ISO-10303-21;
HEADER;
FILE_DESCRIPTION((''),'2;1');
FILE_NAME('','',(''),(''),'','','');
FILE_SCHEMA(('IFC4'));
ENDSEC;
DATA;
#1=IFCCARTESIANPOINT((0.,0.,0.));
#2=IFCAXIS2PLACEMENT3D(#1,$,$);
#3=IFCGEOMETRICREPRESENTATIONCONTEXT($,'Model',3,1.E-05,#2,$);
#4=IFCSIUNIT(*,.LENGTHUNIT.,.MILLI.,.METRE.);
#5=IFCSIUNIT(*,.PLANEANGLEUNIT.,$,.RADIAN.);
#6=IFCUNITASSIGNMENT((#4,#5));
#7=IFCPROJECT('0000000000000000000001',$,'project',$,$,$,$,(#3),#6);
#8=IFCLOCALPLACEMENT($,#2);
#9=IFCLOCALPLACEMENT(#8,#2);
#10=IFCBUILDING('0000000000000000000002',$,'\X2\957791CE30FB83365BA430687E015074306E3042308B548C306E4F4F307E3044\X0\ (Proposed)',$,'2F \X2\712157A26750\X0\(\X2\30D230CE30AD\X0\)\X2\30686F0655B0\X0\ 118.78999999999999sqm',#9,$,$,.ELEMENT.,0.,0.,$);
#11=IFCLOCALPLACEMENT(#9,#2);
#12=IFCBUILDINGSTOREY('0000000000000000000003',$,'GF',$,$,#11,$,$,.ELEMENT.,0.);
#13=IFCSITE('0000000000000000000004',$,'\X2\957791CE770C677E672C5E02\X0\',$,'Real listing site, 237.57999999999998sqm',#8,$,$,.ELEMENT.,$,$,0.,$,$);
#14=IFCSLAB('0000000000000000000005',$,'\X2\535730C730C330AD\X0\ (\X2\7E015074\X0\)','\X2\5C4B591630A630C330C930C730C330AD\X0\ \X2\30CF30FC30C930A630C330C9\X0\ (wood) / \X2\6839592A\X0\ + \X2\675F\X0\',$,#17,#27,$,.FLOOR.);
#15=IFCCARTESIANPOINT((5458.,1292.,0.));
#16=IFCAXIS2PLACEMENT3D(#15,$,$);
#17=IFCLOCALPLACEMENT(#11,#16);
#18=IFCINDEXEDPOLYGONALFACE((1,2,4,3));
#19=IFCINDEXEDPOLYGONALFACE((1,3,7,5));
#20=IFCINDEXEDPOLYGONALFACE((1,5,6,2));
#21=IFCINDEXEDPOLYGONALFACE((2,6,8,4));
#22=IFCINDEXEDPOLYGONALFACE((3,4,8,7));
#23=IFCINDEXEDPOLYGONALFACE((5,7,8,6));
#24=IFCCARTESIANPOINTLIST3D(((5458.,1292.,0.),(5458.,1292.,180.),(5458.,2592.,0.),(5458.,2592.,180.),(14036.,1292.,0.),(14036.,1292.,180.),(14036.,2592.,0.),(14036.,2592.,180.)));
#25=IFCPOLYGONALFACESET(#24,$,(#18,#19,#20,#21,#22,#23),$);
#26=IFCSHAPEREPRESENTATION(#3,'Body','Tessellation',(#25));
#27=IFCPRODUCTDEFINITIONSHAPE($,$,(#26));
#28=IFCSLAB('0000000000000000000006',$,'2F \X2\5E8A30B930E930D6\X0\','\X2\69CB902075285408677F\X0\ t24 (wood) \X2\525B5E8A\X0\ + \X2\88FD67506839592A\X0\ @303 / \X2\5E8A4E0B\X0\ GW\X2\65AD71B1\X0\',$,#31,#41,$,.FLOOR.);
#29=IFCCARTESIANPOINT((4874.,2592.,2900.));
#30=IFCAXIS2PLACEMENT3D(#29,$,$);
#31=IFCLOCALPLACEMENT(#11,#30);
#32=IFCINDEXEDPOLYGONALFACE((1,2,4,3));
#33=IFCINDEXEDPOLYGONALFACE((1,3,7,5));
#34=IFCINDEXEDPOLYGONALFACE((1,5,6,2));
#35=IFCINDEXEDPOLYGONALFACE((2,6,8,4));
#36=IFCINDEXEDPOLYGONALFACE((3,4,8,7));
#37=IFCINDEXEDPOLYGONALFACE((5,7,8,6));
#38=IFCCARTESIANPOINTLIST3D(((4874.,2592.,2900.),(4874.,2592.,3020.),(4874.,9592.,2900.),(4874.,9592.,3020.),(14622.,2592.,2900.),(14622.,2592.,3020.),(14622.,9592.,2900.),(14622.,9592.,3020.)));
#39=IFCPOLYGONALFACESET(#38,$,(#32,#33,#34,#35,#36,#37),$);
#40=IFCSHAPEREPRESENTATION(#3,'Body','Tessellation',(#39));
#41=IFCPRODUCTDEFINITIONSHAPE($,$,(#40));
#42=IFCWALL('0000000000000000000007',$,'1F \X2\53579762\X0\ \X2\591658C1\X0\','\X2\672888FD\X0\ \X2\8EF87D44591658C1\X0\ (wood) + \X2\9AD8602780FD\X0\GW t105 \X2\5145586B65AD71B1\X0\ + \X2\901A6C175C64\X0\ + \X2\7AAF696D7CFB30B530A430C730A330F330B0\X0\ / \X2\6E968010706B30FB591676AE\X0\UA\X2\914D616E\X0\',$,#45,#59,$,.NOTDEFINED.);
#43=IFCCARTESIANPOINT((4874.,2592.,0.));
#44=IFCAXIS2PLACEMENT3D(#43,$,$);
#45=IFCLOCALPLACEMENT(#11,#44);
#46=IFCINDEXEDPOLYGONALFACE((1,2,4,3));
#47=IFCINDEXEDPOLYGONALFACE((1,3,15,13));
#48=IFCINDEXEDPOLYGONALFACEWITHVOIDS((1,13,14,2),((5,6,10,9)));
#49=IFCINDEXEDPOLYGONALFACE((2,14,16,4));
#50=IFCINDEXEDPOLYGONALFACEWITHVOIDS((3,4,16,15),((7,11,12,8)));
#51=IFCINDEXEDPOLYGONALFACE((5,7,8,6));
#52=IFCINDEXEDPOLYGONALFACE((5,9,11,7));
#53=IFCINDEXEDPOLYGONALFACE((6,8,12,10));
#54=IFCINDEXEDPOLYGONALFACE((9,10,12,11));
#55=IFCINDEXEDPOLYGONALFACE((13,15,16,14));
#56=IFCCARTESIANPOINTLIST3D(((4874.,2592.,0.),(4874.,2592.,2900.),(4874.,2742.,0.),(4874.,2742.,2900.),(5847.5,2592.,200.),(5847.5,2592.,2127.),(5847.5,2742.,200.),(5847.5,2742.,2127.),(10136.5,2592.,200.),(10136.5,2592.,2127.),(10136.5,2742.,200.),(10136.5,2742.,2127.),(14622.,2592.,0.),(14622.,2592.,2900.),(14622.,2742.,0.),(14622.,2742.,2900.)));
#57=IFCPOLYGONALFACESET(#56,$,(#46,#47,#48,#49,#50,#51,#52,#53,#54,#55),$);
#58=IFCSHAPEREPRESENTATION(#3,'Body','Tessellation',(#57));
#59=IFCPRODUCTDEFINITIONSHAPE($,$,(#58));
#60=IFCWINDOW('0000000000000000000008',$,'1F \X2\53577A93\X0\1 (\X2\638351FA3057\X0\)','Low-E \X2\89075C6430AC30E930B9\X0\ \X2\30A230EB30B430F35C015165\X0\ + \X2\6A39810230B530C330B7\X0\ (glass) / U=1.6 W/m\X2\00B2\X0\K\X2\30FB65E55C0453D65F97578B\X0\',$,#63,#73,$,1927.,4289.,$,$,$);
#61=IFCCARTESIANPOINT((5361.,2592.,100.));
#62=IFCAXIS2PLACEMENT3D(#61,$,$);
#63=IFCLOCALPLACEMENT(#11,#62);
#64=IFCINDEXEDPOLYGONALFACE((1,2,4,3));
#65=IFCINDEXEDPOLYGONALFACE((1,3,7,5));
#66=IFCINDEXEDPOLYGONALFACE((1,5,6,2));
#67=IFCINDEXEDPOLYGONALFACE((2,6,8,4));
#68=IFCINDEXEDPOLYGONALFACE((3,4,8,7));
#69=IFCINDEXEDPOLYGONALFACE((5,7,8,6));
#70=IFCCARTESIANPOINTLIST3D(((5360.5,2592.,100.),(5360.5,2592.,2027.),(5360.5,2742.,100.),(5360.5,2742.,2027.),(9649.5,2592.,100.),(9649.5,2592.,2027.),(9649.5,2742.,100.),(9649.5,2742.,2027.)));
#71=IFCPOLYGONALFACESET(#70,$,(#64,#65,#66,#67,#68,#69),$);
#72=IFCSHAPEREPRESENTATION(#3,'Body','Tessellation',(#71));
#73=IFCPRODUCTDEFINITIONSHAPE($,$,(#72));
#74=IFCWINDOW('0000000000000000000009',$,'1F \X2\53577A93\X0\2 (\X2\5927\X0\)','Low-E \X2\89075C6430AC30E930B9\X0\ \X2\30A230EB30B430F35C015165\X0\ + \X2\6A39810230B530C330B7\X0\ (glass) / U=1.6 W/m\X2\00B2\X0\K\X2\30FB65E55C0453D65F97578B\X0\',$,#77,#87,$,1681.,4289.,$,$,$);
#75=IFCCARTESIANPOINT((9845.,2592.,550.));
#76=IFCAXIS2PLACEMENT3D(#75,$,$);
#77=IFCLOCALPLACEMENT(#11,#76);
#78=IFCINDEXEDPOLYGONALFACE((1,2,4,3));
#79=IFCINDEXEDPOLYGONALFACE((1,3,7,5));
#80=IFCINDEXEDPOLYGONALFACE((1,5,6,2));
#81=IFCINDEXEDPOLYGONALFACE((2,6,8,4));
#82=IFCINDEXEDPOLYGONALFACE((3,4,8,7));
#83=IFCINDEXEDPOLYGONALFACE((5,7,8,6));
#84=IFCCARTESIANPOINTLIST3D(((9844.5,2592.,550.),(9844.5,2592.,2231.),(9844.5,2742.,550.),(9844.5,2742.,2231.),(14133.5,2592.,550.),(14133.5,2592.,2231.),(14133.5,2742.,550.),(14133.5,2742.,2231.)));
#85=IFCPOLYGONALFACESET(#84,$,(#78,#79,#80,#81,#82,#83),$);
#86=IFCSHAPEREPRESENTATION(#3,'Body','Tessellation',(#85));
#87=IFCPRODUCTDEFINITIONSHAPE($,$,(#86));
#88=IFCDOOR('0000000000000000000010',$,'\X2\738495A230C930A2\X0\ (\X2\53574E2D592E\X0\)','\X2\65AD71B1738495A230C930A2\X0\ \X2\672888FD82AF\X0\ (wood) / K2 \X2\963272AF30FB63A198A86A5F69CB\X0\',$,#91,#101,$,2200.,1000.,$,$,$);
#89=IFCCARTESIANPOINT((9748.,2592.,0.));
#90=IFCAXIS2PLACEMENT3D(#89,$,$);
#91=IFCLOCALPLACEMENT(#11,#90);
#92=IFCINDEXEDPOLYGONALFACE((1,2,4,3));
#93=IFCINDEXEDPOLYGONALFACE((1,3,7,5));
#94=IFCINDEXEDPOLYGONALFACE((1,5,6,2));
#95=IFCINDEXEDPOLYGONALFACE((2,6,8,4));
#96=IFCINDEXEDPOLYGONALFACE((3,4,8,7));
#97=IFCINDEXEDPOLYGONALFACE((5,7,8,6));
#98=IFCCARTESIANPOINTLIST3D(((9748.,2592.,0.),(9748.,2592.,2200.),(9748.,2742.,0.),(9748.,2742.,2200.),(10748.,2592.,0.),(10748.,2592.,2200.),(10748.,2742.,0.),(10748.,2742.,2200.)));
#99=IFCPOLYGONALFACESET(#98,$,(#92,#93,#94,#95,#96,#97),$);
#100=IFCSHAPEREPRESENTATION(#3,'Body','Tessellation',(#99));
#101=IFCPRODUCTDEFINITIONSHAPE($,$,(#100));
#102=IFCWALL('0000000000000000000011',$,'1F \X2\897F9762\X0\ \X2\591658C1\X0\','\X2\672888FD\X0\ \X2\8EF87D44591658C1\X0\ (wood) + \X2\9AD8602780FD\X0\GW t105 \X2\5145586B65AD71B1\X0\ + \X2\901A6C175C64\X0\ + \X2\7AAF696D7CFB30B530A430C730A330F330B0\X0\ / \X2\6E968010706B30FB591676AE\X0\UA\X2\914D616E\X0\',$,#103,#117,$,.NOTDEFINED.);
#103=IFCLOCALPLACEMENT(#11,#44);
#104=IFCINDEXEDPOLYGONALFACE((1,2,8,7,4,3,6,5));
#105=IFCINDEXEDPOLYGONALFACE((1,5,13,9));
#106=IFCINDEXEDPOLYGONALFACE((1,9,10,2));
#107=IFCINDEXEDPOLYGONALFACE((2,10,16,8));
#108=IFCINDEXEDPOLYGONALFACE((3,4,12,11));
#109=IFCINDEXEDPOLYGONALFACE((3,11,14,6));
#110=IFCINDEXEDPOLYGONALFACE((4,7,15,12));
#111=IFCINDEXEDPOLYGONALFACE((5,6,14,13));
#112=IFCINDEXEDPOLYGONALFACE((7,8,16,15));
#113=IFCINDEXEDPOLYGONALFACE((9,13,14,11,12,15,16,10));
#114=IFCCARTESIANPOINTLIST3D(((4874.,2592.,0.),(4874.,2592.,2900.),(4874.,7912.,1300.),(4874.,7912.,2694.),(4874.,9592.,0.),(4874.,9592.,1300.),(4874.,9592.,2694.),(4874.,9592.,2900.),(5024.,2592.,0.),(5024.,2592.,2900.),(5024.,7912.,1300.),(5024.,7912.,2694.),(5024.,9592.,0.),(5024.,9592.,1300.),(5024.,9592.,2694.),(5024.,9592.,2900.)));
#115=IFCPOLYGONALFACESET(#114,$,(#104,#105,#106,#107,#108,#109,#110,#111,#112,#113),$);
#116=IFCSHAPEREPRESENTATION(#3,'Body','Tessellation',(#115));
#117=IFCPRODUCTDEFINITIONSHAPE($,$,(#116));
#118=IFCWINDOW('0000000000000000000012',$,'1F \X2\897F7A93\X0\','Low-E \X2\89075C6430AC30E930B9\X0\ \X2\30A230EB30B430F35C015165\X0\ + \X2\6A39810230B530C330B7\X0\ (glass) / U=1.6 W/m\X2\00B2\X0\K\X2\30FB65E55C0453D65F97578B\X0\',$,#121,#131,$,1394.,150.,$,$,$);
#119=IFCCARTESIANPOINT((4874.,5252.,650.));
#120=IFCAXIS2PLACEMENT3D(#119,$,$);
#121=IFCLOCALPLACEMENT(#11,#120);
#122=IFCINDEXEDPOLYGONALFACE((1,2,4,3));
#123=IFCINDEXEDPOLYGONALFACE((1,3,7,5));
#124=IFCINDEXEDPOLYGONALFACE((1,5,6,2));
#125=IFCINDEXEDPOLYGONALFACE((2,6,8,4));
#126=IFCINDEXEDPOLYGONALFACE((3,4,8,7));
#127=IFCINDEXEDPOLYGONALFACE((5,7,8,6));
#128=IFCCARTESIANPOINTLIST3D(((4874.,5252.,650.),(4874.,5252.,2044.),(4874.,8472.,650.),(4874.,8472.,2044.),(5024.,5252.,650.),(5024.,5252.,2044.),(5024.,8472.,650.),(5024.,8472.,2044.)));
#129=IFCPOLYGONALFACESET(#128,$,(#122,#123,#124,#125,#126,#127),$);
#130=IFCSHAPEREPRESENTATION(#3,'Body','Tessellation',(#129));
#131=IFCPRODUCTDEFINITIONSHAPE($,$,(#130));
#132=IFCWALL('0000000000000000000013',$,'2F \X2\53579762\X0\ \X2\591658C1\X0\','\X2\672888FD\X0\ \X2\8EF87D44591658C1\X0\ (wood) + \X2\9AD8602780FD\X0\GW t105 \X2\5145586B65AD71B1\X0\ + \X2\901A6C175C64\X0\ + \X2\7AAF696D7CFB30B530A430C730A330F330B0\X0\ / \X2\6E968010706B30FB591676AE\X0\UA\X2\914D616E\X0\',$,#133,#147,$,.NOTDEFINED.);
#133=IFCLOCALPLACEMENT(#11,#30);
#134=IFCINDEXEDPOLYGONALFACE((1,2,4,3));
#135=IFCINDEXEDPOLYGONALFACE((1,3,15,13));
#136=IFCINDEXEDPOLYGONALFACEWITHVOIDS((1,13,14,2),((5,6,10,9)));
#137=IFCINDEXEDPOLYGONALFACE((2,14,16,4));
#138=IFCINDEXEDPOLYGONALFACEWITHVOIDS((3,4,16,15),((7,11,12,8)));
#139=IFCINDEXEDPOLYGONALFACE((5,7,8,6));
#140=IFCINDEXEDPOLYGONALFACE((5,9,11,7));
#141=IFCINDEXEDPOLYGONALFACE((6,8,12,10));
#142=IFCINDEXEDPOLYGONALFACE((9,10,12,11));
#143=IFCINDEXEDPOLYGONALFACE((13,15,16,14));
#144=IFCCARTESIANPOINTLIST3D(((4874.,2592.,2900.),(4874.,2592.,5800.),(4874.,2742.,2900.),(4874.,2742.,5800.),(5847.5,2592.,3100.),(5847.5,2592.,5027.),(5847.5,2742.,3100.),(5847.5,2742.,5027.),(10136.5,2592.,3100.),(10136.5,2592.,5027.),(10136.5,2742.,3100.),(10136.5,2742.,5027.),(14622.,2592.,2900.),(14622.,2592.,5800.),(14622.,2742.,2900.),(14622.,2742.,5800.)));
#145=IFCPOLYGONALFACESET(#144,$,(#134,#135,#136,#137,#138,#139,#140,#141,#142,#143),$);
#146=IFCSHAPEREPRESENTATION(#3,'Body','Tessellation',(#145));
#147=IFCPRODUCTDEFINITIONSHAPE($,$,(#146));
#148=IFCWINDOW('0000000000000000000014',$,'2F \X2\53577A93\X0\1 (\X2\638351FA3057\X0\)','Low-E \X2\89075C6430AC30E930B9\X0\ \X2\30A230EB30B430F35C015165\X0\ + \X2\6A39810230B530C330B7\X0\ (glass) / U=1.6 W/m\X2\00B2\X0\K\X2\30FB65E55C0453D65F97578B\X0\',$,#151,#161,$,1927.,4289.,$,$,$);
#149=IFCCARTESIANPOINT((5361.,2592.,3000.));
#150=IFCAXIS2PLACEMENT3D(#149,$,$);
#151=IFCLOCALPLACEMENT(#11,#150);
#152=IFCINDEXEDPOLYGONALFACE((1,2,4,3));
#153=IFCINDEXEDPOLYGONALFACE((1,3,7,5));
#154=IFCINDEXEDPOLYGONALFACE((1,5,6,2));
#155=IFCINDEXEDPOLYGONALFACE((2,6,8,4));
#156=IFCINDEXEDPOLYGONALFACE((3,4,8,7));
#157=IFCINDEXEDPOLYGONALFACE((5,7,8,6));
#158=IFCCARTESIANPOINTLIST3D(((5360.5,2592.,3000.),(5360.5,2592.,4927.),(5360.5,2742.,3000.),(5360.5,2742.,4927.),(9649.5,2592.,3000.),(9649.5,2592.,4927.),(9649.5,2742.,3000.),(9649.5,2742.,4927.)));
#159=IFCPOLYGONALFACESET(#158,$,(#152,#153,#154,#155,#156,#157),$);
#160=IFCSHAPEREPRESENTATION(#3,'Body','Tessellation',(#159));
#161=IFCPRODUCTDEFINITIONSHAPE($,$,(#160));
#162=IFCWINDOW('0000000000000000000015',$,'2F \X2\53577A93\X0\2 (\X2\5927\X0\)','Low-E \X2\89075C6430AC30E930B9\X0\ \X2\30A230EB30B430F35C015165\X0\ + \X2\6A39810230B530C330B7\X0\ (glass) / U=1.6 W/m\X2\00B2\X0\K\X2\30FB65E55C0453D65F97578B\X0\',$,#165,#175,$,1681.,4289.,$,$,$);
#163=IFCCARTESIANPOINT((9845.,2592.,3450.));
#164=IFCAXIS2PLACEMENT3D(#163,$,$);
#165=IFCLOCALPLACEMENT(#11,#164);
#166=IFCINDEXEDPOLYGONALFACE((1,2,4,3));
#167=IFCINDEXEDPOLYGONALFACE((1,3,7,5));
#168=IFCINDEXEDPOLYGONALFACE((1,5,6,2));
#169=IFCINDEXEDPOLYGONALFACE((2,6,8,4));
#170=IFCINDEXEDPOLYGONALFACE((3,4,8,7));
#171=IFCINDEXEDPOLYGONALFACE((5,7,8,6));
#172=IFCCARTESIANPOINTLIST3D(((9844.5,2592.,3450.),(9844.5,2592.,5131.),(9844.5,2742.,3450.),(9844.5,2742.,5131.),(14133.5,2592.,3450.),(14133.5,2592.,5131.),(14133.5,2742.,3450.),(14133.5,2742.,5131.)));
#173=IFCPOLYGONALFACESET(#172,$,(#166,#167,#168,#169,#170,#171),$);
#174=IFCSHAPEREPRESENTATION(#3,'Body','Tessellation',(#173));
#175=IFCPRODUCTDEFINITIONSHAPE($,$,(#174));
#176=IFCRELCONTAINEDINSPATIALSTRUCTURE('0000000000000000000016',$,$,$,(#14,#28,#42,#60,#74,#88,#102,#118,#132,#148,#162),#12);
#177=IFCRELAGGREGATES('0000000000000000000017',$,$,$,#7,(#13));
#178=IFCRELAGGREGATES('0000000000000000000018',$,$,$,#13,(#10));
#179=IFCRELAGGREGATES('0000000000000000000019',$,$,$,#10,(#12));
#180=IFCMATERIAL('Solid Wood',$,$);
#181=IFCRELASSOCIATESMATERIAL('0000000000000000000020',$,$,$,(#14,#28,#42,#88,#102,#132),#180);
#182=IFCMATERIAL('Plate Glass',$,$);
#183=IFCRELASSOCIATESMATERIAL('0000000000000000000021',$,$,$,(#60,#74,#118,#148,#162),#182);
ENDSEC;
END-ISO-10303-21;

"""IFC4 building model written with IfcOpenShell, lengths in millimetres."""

from ifc_helpers import new_model, si_unit, frame, frame_2d, origin, place, context, project, spatial, rectangle, extrude, material, element, fill, save


model = new_model("IFC4")

# Units and contexts
model_context = context("Model", 3, precision=1e-05, world=origin())
ifc_project = project(units=[si_unit("LENGTHUNIT", "METRE", prefix="MILLI"), si_unit("PLANEANGLEUNIT", "RADIAN")], contexts=[model_context])

# Site, building, storey
site_placement = place(None, origin())
site = spatial("IfcSite", under=ifc_project, at=site_placement, Name="長野県松本市", ObjectType="Real listing site, 237.57999999999998sqm", CompositionType="ELEMENT", RefElevation=0.0)
building_placement = place(site_placement, origin())
building = spatial("IfcBuilding", under=site, at=building_placement, Name="長野・茶室と縁側のある和の住まい (Proposed)", ObjectType="2F 無垢材(ヒノキ)と漆喰 118.78999999999999sqm", CompositionType="ELEMENT", ElevationOfRefHeight=0.0, ElevationOfTerrain=0.0)
storey_placement = place(building_placement, origin())
storey = spatial("IfcBuildingStorey", under=building, at=storey_placement, Name="GF", CompositionType="ELEMENT", Elevation=0.0)

# Slabs
ifc_material_1 = material(Name="Solid Wood")
slab_1_placement = place(storey_placement, frame((5458.0, 1292.0, 0.0)))
element("IfcSlab", 1, at=slab_1_placement, inside=storey, material=ifc_material_1, Name="南デッキ (縁側)", Description="屋外ウッドデッキ ハードウッド (wood) / 根太 + 束", PredefinedType="FLOOR", context=model_context, shape_type="SweptSolid", body=[
    extrude(rectangle(XDim=8578.0, YDim=1300.0, at=frame_2d((4289.0, 650.0))), frame((5458.0, 1292.0, 0.0)), (0.0, 0.0, 1.0), 180.0),
])
slab_2_placement = place(storey_placement, frame((4874.0, 2592.0, 2900.0)))
element("IfcSlab", 2, at=slab_2_placement, inside=storey, material=ifc_material_1, Name="2F 床スラブ", Description="構造用合板 t24 (wood) 剛床 + 製材根太 @303 / 床下 GW断熱", PredefinedType="FLOOR", context=model_context, shape_type="SweptSolid", body=[
    extrude(rectangle(XDim=9748.0, YDim=7000.0, at=frame_2d((4874.0, 3500.0))), frame((4874.0, 2592.0, 2900.0)), (0.0, 0.0, 1.0), 120.0),
])

# Wall, openings, windows, door
wall_1_placement = place(storey_placement, frame((4874.0, 2592.0, 0.0)))
wall_1 = element("IfcWall", 3, at=wall_1_placement, inside=storey, material=ifc_material_1, Name="1F 南面 外壁", Description="木製 軸組外壁 (wood) + 高性能GW t105 充填断熱 + 通気層 + 窯業系サイディング / 準耐火・外皮UA配慮", PredefinedType="NOTDEFINED", context=model_context, shape_type="SweptSolid", body=[
    extrude(rectangle(XDim=9748.0, YDim=150.0, at=frame_2d((4874.0, 75.0))), frame((4874.0, 2592.0, 0.0)), (0.0, 0.0, 1.0), 2900.0),
])
opening_1_placement = place(storey_placement, frame((5361.0, 2592.0, 100.0)))
opening_1 = element("IfcOpeningElement", 4, at=opening_1_placement, cuts=wall_1, PredefinedType="NOTDEFINED", context=model_context, shape_type="SweptSolid", body=[
    extrude(rectangle(XDim=4289.0, YDim=150.0, at=frame_2d((2144.0, 75.0))), frame((5361.0, 2592.0, 100.0)), (0.0, 0.0, 1.0), 1927.0),
])
opening_2_placement = place(storey_placement, frame((9845.0, 2592.0, 550.0)))
opening_2 = element("IfcOpeningElement", 5, at=opening_2_placement, cuts=wall_1, PredefinedType="NOTDEFINED", context=model_context, shape_type="SweptSolid", body=[
    extrude(rectangle(XDim=4289.0, YDim=150.0, at=frame_2d((2144.0, 75.0))), frame((9845.0, 2592.0, 550.0)), (0.0, 0.0, 1.0), 1681.0),
])
opening_3_placement = place(storey_placement, frame((9748.0, 2592.0, 0.0)))
opening_3 = element("IfcOpeningElement", 6, at=opening_3_placement, cuts=wall_1, PredefinedType="NOTDEFINED", context=model_context, shape_type="SweptSolid", body=[
    extrude(rectangle(XDim=1000.0, YDim=150.0, at=frame_2d((500.0, 75.0))), frame((9748.0, 2592.0, 0.0)), (0.0, 0.0, 1.0), 2200.0),
])
ifc_material_2 = material(Name="Plate Glass")
window_1_placement = place(storey_placement, frame((5361.0, 2592.0, 100.0)))
window_1 = element("IfcWindow", 7, at=window_1_placement, inside=storey, material=ifc_material_2, Name="1F 南窓1 (掃出し)", Description="Low-E 複層ガラス アルゴン封入 + 樹脂サッシ (glass) / U=1.6 W/m²K・日射取得型", OverallHeight=1927.0, OverallWidth=4289.0, context=model_context, shape_type="SweptSolid", body=[
    extrude(rectangle(XDim=4289.0, YDim=150.0, at=frame_2d((2144.0, 75.0))), frame((5361.0, 2592.0, 100.0)), (0.0, 0.0, 1.0), 1927.0),
])
fill(opening_1, window_1)
window_2_placement = place(storey_placement, frame((9845.0, 2592.0, 550.0)))
window_2 = element("IfcWindow", 8, at=window_2_placement, inside=storey, material=ifc_material_2, Name="1F 南窓2 (大)", Description="Low-E 複層ガラス アルゴン封入 + 樹脂サッシ (glass) / U=1.6 W/m²K・日射取得型", OverallHeight=1681.0, OverallWidth=4289.0, context=model_context, shape_type="SweptSolid", body=[
    extrude(rectangle(XDim=4289.0, YDim=150.0, at=frame_2d((2144.0, 75.0))), frame((9845.0, 2592.0, 550.0)), (0.0, 0.0, 1.0), 1681.0),
])
fill(opening_2, window_2)
door_placement = place(storey_placement, frame((9748.0, 2592.0, 0.0)))
door = element("IfcDoor", 9, at=door_placement, inside=storey, material=ifc_material_1, Name="玄関ドア (南中央)", Description="断熱玄関ドア 木製芯 (wood) / K2 防犯・採風機構", OverallHeight=2200.0, OverallWidth=1000.0, context=model_context, shape_type="SweptSolid", body=[
    extrude(rectangle(XDim=1000.0, YDim=150.0, at=frame_2d((500.0, 75.0))), frame((9748.0, 2592.0, 0.0)), (0.0, 0.0, 1.0), 2200.0),
])
fill(opening_3, door)

# Wall, opening, window
wall_2_placement = place(storey_placement, frame((4874.0, 2592.0, 0.0)))
wall_2 = element("IfcWall", 10, at=wall_2_placement, inside=storey, material=ifc_material_1, Name="1F 西面 外壁", Description="木製 軸組外壁 (wood) + 高性能GW t105 充填断熱 + 通気層 + 窯業系サイディング / 準耐火・外皮UA配慮", PredefinedType="NOTDEFINED", context=model_context, shape_type="SweptSolid", body=[
    extrude(rectangle(XDim=150.0, YDim=7000.0, at=frame_2d((75.0, 3500.0))), frame((4874.0, 2592.0, 0.0)), (0.0, 0.0, 1.0), 2900.0),
])
opening_4_placement = place(storey_placement, frame((4874.0, 5252.0, 650.0)))
opening_4 = element("IfcOpeningElement", 11, at=opening_4_placement, cuts=wall_2, PredefinedType="NOTDEFINED", context=model_context, shape_type="SweptSolid", body=[
    extrude(rectangle(XDim=150.0, YDim=3220.0, at=frame_2d((75.0, 1610.0))), frame((4874.0, 5252.0, 650.0)), (0.0, 0.0, 1.0), 1394.0),
])
window_3_placement = place(storey_placement, frame((4874.0, 5252.0, 650.0)))
window_3 = element("IfcWindow", 12, at=window_3_placement, inside=storey, material=ifc_material_2, Name="1F 西窓", Description="Low-E 複層ガラス アルゴン封入 + 樹脂サッシ (glass) / U=1.6 W/m²K・日射取得型", OverallHeight=1394.0, OverallWidth=150.0, context=model_context, shape_type="SweptSolid", body=[
    extrude(rectangle(XDim=150.0, YDim=3220.0, at=frame_2d((75.0, 1610.0))), frame((4874.0, 5252.0, 650.0)), (0.0, 0.0, 1.0), 1394.0),
])
fill(opening_4, window_3)

# Wall, openings, windows
wall_3_placement = place(storey_placement, frame((4874.0, 2592.0, 2900.0)))
wall_3 = element("IfcWall", 13, at=wall_3_placement, inside=storey, material=ifc_material_1, Name="2F 南面 外壁", Description="木製 軸組外壁 (wood) + 高性能GW t105 充填断熱 + 通気層 + 窯業系サイディング / 準耐火・外皮UA配慮", PredefinedType="NOTDEFINED", context=model_context, shape_type="SweptSolid", body=[
    extrude(rectangle(XDim=9748.0, YDim=150.0, at=frame_2d((4874.0, 75.0))), frame((4874.0, 2592.0, 2900.0)), (0.0, 0.0, 1.0), 2900.0),
])
opening_5_placement = place(storey_placement, frame((5361.0, 2592.0, 3000.0)))
opening_5 = element("IfcOpeningElement", 14, at=opening_5_placement, cuts=wall_3, PredefinedType="NOTDEFINED", context=model_context, shape_type="SweptSolid", body=[
    extrude(rectangle(XDim=4289.0, YDim=150.0, at=frame_2d((2144.0, 75.0))), frame((5361.0, 2592.0, 3000.0)), (0.0, 0.0, 1.0), 1927.0),
])
opening_6_placement = place(storey_placement, frame((9845.0, 2592.0, 3450.0)))
opening_6 = element("IfcOpeningElement", 15, at=opening_6_placement, cuts=wall_3, PredefinedType="NOTDEFINED", context=model_context, shape_type="SweptSolid", body=[
    extrude(rectangle(XDim=4289.0, YDim=150.0, at=frame_2d((2144.0, 75.0))), frame((9845.0, 2592.0, 3450.0)), (0.0, 0.0, 1.0), 1681.0),
])
window_4_placement = place(storey_placement, frame((5361.0, 2592.0, 3000.0)))
window_4 = element("IfcWindow", 16, at=window_4_placement, inside=storey, material=ifc_material_2, Name="2F 南窓1 (掃出し)", Description="Low-E 複層ガラス アルゴン封入 + 樹脂サッシ (glass) / U=1.6 W/m²K・日射取得型", OverallHeight=1927.0, OverallWidth=4289.0, context=model_context, shape_type="SweptSolid", body=[
    extrude(rectangle(XDim=4289.0, YDim=150.0, at=frame_2d((2144.0, 75.0))), frame((5361.0, 2592.0, 3000.0)), (0.0, 0.0, 1.0), 1927.0),
])
fill(opening_5, window_4)
window_5_placement = place(storey_placement, frame((9845.0, 2592.0, 3450.0)))
window_5 = element("IfcWindow", 17, at=window_5_placement, inside=storey, material=ifc_material_2, Name="2F 南窓2 (大)", Description="Low-E 複層ガラス アルゴン封入 + 樹脂サッシ (glass) / U=1.6 W/m²K・日射取得型", OverallHeight=1681.0, OverallWidth=4289.0, context=model_context, shape_type="SweptSolid", body=[
    extrude(rectangle(XDim=4289.0, YDim=150.0, at=frame_2d((2144.0, 75.0))), frame((9845.0, 2592.0, 3450.0)), (0.0, 0.0, 1.0), 1681.0),
])
fill(opening_6, window_5)

save(model, "model.ifc")
